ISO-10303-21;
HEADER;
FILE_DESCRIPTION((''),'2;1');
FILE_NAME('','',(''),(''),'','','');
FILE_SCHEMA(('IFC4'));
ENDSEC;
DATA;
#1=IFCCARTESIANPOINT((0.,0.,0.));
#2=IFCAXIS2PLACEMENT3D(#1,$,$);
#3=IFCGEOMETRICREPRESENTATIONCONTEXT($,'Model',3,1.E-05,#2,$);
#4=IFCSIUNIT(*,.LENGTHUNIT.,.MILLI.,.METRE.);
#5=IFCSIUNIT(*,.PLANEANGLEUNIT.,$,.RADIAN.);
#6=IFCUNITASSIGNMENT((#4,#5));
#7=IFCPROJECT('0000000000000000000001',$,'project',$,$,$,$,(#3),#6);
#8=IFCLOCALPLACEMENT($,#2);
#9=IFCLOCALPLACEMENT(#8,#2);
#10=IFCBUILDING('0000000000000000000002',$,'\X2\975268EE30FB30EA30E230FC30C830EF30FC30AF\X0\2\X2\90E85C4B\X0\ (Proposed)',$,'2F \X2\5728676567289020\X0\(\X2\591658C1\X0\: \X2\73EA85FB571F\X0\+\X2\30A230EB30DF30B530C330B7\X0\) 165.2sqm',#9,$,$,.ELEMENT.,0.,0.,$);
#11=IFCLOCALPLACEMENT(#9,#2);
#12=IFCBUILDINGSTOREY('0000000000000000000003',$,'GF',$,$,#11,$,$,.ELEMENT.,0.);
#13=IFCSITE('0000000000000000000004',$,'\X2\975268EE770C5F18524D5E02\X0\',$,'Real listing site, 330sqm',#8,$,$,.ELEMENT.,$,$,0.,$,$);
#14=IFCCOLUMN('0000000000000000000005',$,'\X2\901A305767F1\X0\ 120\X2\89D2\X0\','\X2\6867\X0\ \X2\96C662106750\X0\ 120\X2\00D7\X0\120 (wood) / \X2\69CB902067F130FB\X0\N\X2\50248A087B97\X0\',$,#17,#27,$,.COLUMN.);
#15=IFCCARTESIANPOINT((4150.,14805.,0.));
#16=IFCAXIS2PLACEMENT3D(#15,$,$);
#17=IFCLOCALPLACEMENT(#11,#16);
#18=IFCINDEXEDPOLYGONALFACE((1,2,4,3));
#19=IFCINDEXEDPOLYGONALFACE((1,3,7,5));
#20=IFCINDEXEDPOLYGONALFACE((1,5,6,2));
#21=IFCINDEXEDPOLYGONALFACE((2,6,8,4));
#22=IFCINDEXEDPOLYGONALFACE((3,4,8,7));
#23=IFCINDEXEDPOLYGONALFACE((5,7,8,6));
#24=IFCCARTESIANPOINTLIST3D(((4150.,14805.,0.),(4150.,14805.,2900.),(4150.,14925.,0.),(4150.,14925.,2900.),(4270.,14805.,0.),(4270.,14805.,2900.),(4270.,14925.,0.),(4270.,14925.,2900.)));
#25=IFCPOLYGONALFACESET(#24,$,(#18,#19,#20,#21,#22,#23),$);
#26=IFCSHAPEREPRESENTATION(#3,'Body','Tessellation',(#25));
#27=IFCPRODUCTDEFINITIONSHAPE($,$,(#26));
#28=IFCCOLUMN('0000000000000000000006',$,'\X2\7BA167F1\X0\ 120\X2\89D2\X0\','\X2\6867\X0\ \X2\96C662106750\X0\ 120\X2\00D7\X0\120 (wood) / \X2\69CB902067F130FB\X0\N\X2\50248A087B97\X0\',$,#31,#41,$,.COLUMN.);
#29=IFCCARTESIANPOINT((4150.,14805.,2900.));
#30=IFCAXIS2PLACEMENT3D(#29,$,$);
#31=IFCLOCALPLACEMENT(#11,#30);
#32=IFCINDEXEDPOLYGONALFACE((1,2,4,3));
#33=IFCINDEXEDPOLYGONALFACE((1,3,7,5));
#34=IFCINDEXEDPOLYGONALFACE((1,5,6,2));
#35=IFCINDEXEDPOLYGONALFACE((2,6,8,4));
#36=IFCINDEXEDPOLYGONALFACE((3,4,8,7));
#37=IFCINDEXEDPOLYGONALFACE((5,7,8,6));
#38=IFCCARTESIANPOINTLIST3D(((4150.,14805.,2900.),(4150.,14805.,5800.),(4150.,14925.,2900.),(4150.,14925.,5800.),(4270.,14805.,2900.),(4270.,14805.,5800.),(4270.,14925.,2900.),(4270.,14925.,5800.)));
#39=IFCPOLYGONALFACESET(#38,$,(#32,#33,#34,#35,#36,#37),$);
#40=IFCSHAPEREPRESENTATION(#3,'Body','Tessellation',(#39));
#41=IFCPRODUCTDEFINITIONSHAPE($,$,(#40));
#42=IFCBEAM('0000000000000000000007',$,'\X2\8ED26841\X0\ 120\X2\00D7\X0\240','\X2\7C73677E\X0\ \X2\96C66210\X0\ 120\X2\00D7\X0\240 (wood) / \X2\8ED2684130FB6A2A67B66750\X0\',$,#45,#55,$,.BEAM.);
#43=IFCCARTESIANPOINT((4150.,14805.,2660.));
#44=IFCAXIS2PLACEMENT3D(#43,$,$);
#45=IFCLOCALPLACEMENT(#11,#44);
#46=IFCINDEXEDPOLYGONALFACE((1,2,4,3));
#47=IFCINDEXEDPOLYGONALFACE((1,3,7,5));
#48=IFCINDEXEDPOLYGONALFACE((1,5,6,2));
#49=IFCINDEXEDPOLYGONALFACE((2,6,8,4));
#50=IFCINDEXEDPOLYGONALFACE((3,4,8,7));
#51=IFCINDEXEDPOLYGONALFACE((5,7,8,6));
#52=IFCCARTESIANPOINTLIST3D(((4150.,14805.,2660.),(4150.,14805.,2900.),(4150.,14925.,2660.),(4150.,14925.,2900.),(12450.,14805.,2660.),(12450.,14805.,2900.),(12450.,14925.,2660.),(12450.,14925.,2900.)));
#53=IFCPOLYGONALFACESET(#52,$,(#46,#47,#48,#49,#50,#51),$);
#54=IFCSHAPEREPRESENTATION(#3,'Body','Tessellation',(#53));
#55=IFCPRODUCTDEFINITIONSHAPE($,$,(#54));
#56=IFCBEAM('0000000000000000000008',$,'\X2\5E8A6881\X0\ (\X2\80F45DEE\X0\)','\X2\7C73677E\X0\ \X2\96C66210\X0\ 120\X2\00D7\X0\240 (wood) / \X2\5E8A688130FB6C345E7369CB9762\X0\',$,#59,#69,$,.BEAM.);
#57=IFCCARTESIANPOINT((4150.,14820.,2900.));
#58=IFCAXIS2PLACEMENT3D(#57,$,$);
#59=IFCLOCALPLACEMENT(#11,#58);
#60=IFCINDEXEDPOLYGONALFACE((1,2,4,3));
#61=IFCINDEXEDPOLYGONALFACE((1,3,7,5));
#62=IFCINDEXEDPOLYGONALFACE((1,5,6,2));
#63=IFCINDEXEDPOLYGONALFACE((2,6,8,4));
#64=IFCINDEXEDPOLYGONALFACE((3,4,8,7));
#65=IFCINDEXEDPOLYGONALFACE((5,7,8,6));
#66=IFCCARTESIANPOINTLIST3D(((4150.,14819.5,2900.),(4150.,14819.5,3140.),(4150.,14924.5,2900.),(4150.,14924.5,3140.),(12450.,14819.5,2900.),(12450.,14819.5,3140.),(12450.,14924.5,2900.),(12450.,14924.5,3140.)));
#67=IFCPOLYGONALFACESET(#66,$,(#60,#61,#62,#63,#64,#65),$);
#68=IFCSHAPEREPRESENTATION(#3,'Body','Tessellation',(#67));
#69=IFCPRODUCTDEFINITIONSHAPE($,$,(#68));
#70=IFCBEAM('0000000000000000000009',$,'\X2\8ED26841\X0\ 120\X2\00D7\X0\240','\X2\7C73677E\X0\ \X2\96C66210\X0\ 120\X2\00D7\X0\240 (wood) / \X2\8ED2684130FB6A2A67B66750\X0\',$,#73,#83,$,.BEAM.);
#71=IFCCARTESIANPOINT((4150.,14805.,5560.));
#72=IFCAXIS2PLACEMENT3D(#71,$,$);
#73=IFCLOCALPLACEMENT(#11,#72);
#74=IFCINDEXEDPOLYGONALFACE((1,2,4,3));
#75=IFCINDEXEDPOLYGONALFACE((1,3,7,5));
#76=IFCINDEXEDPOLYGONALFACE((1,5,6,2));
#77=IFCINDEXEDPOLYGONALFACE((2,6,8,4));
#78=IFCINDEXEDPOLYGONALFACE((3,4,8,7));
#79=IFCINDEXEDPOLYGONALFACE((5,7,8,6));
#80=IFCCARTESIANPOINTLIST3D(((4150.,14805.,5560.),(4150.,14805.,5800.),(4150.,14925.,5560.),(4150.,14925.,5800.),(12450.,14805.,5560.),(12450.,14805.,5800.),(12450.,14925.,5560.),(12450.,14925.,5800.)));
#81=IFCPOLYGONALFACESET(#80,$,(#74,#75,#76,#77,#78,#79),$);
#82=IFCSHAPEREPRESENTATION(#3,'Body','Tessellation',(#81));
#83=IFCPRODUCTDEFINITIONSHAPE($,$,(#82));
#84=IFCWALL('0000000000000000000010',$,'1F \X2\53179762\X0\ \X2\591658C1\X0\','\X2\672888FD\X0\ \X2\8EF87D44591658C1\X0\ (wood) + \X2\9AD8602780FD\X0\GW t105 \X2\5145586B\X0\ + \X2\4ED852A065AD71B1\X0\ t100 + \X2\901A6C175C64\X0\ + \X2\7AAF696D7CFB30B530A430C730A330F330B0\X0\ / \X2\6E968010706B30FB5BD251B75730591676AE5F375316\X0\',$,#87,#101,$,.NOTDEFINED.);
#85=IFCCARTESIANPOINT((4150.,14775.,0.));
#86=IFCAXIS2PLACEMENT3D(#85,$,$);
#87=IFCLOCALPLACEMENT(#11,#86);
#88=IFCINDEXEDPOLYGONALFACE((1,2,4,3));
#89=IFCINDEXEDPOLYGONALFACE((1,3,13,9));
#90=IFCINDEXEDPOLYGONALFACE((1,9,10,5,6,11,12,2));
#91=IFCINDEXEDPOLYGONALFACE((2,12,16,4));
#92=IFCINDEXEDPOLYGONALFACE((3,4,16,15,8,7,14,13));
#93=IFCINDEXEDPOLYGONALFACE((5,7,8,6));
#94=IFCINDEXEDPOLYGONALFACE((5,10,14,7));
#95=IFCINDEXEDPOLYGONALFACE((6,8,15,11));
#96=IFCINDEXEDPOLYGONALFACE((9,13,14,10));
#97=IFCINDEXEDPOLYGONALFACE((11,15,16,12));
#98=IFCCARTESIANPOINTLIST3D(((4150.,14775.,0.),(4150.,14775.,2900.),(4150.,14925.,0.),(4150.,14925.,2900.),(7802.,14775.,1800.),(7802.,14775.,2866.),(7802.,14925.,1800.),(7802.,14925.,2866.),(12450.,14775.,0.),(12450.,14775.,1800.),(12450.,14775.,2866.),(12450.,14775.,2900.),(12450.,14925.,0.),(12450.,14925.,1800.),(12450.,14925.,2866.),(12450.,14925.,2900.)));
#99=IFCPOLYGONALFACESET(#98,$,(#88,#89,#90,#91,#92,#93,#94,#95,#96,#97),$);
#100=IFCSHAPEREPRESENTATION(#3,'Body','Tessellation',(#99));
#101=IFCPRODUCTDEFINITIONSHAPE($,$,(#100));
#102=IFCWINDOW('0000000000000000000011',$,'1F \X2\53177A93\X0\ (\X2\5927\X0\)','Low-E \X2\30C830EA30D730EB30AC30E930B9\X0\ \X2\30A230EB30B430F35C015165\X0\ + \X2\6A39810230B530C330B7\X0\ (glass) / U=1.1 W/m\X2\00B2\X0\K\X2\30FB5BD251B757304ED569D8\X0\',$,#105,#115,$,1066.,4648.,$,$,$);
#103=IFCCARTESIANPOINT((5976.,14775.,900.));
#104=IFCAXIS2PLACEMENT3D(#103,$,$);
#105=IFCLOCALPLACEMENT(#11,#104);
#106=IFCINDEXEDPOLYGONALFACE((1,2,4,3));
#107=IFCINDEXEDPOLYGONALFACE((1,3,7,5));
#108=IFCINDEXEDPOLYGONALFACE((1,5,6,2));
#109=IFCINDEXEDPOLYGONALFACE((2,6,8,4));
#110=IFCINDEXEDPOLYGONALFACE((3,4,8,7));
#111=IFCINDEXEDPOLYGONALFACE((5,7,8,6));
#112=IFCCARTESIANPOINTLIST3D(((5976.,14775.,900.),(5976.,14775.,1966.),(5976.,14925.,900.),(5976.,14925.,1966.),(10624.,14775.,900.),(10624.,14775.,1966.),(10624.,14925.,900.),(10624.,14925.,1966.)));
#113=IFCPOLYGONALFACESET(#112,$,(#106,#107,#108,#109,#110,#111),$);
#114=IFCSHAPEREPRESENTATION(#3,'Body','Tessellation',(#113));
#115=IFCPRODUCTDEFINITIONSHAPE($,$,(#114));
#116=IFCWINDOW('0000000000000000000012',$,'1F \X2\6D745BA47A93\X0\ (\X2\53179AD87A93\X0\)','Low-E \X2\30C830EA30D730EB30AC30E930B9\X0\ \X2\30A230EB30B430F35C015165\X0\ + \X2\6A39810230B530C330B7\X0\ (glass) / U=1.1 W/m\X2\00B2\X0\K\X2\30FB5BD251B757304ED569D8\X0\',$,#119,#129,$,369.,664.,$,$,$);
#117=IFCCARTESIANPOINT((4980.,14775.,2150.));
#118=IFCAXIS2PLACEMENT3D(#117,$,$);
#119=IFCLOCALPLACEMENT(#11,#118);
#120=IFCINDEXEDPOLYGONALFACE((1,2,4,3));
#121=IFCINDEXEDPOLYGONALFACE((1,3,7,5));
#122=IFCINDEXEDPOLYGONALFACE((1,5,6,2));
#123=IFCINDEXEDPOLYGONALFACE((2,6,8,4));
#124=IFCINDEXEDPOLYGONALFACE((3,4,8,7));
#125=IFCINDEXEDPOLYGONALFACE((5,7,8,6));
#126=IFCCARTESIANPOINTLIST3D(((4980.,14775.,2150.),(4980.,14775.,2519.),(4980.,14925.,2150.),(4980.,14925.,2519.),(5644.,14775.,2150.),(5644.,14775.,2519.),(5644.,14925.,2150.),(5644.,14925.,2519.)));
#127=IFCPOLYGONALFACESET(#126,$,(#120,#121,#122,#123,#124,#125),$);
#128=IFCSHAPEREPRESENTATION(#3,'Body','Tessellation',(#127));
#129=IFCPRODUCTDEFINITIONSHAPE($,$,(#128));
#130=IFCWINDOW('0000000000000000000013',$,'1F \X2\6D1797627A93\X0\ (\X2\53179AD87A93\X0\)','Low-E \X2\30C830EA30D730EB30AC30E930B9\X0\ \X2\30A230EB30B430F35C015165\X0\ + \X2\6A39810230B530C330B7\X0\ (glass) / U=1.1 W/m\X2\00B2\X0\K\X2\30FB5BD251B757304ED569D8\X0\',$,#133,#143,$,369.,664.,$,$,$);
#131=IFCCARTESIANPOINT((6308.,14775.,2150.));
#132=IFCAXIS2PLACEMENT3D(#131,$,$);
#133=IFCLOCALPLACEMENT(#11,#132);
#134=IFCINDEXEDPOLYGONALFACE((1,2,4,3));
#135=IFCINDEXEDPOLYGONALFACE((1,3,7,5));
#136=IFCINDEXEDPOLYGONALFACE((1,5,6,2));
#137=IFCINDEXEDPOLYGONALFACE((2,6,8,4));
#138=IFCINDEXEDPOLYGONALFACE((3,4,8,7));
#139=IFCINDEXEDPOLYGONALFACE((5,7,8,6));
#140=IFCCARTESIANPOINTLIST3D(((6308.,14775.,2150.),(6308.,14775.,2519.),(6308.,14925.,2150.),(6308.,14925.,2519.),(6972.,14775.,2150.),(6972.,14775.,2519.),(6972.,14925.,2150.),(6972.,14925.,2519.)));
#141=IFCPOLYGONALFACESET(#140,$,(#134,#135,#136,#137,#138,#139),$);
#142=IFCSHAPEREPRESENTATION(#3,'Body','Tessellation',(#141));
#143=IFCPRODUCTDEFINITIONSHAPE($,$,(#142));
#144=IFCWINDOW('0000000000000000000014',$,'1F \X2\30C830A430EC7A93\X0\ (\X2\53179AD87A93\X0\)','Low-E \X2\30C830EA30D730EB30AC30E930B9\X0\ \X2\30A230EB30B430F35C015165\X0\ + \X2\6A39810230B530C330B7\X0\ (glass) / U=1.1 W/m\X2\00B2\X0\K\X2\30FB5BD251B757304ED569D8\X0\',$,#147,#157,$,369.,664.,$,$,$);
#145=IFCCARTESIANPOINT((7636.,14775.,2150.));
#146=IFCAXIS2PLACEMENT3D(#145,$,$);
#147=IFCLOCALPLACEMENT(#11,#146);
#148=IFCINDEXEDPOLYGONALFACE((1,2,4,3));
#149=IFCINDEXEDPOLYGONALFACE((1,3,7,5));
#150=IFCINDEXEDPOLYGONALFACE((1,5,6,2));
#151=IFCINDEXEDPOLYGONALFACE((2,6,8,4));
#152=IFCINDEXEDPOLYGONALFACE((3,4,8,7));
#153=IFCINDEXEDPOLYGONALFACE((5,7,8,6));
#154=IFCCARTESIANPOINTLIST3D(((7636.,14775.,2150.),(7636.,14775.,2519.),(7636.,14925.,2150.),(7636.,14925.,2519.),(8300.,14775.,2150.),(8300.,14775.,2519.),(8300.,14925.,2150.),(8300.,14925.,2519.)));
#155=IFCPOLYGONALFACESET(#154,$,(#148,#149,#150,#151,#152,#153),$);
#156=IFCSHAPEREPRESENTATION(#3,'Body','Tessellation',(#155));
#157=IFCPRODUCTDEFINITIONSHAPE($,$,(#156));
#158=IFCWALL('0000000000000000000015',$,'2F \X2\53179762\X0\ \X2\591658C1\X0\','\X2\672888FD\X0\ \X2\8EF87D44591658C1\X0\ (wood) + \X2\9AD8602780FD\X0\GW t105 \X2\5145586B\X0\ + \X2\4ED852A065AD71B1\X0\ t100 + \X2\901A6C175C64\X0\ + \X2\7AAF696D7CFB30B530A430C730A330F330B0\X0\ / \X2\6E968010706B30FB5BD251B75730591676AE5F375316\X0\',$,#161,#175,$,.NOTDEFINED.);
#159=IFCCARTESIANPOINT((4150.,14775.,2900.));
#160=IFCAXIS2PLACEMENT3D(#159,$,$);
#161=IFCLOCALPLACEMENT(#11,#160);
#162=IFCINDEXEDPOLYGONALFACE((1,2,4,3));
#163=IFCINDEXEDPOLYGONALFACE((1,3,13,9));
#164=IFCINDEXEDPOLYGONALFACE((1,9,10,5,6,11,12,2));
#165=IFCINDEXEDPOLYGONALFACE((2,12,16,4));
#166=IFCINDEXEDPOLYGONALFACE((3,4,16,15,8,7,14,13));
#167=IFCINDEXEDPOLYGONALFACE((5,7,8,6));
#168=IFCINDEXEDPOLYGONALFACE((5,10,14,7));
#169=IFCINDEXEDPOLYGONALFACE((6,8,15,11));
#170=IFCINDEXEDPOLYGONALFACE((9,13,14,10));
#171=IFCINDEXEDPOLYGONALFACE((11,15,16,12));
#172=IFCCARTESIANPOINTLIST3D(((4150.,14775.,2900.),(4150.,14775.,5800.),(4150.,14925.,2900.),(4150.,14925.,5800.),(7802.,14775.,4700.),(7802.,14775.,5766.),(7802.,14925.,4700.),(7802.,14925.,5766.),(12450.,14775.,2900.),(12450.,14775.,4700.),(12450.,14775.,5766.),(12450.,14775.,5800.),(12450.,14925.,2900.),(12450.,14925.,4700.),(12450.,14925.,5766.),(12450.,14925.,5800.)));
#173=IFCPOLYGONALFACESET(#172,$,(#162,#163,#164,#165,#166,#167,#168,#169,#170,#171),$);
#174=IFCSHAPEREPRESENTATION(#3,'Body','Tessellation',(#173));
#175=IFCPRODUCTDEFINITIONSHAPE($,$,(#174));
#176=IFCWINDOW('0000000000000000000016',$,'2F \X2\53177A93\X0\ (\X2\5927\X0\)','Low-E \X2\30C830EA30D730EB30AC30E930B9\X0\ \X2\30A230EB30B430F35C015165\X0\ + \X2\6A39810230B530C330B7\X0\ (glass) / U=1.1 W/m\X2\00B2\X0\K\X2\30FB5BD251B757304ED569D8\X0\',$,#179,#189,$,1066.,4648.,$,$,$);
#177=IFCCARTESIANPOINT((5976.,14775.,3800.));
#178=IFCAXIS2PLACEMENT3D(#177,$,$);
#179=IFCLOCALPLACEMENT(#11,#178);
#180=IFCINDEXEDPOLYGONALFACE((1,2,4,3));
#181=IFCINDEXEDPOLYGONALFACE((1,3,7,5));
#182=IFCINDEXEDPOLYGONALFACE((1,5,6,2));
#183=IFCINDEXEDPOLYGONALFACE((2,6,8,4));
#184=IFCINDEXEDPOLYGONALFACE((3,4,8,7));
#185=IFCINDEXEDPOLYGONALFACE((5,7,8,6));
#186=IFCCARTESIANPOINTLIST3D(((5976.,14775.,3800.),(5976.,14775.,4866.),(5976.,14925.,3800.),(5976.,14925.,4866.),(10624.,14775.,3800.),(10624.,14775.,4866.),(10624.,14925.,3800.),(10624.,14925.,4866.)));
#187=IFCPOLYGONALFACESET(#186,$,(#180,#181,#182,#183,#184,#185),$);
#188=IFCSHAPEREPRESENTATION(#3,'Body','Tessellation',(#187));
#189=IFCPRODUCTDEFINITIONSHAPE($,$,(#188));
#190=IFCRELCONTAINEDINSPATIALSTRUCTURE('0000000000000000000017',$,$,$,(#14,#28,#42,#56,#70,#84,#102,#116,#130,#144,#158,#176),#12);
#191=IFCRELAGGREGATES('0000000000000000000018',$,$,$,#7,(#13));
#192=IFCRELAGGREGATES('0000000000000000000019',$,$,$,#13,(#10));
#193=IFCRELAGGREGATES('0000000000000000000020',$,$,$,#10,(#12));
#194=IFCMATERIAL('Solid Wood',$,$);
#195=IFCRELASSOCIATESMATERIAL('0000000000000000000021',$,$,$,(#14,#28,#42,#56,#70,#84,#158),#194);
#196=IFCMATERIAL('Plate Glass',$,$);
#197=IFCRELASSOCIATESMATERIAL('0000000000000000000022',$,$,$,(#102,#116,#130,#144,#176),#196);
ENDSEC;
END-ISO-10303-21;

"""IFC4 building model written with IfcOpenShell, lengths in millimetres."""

from ifc_helpers import new_model, si_unit, frame, frame_2d, origin, place, context, project, spatial, rectangle, extrude, material, element, fill, save


model = new_model("IFC4")

# Units and contexts
model_context = context("Model", 3, precision=1e-05, world=origin())
ifc_project = project(units=[si_unit("LENGTHUNIT", "METRE", prefix="MILLI"), si_unit("PLANEANGLEUNIT", "RADIAN")], contexts=[model_context])

# Site, building, storey
site_placement = place(None, origin())
site = spatial("IfcSite", under=ifc_project, at=site_placement, Name="青森県弘前市", ObjectType="Real listing site, 330sqm", CompositionType="ELEMENT", RefElevation=0.0)
building_placement = place(site_placement, origin())
building = spatial("IfcBuilding", under=site, at=building_placement, Name="青森・リモートワーク2部屋 (Proposed)", ObjectType="2F 在来木造(外壁: 珪藻土+アルミサッシ) 165.2sqm", CompositionType="ELEMENT", ElevationOfRefHeight=0.0, ElevationOfTerrain=0.0)
storey_placement = place(building_placement, origin())
storey = spatial("IfcBuildingStorey", under=building, at=storey_placement, Name="GF", CompositionType="ELEMENT", Elevation=0.0)

# Columns
ifc_material_1 = material(Name="Solid Wood")
column_1_placement = place(storey_placement, frame((4150.0, 14805.0, 0.0)))
element("IfcColumn", 1, at=column_1_placement, inside=storey, material=ifc_material_1, Name="通し柱 120角", Description="桧 集成材 120×120 (wood) / 構造柱・N値計算", PredefinedType="COLUMN", context=model_context, shape_type="SweptSolid", body=[
    extrude(rectangle(XDim=120.0, YDim=120.0, at=frame_2d((60.0, 60.0))), frame((4150.0, 14805.0, 0.0)), (0.0, 0.0, 1.0), 2900.0),
])
column_2_placement = place(storey_placement, frame((4150.0, 14805.0, 2900.0)))
element("IfcColumn", 2, at=column_2_placement, inside=storey, material=ifc_material_1, Name="管柱 120角", Description="桧 集成材 120×120 (wood) / 構造柱・N値計算", PredefinedType="COLUMN", context=model_context, shape_type="SweptSolid", body=[
    extrude(rectangle(XDim=120.0, YDim=120.0, at=frame_2d((60.0, 60.0))), frame((4150.0, 14805.0, 2900.0)), (0.0, 0.0, 1.0), 2900.0),
])

# Beams
beam_1_placement = place(storey_placement, frame((4150.0, 14805.0, 2660.0)))
element("IfcBeam", 3, at=beam_1_placement, inside=storey, material=ifc_material_1, Name="軒桁 120×240", Description="米松 集成 120×240 (wood) / 軒桁・横架材", PredefinedType="BEAM", context=model_context, shape_type="SweptSolid", body=[
    extrude(rectangle(XDim=8300.0, YDim=120.0, at=frame_2d((4150.0, 60.0))), frame((4150.0, 14805.0, 2660.0)), (0.0, 0.0, 1.0), 240.0),
])
beam_2_placement = place(storey_placement, frame((4150.0, 14820.0, 2900.0)))
element("IfcBeam", 4, at=beam_2_placement, inside=storey, material=ifc_material_1, Name="床梁 (胴差)", Description="米松 集成 120×240 (wood) / 床梁・水平構面", PredefinedType="BEAM", context=model_context, shape_type="SweptSolid", body=[
    extrude(rectangle(XDim=8300.0, YDim=105.0, at=frame_2d((4150.0, 52.0))), frame((4150.0, 14820.0, 2900.0)), (0.0, 0.0, 1.0), 240.0),
])
beam_3_placement = place(storey_placement, frame((4150.0, 14805.0, 5560.0)))
element("IfcBeam", 5, at=beam_3_placement, inside=storey, material=ifc_material_1, Name="軒桁 120×240", Description="米松 集成 120×240 (wood) / 軒桁・横架材", PredefinedType="BEAM", context=model_context, shape_type="SweptSolid", body=[
    extrude(rectangle(XDim=8300.0, YDim=120.0, at=frame_2d((4150.0, 60.0))), frame((4150.0, 14805.0, 5560.0)), (0.0, 0.0, 1.0), 240.0),
])

# Wall, openings, windows
wall_1_placement = place(storey_placement, frame((4150.0, 14775.0, 0.0)))
wall_1 = element("IfcWall", 6, at=wall_1_placement, inside=storey, material=ifc_material_1, Name="1F 北面 外壁", Description="木製 軸組外壁 (wood) + 高性能GW t105 充填 + 付加断熱 t100 + 通気層 + 窯業系サイディング / 準耐火・寒冷地外皮強化", PredefinedType="NOTDEFINED", context=model_context, shape_type="SweptSolid", body=[
    extrude(rectangle(XDim=8300.0, YDim=150.0, at=frame_2d((4150.0, 75.0))), frame((4150.0, 14775.0, 0.0)), (0.0, 0.0, 1.0), 2900.0),
])
opening_1_placement = place(storey_placement, frame((5976.0, 14775.0, 900.0)))
opening_1 = element("IfcOpeningElement", 7, at=opening_1_placement, cuts=wall_1, PredefinedType="NOTDEFINED", context=model_context, shape_type="SweptSolid", body=[
    extrude(rectangle(XDim=4648.0, YDim=150.0, at=frame_2d((2324.0, 75.0))), frame((5976.0, 14775.0, 900.0)), (0.0, 0.0, 1.0), 1066.0),
])
opening_2_placement = place(storey_placement, frame((4980.0, 14775.0, 2150.0)))
opening_2 = element("IfcOpeningElement", 8, at=opening_2_placement, cuts=wall_1, PredefinedType="NOTDEFINED", context=model_context, shape_type="SweptSolid", body=[
    extrude(rectangle(XDim=664.0, YDim=150.0, at=frame_2d((332.0, 75.0))), frame((4980.0, 14775.0, 2150.0)), (0.0, 0.0, 1.0), 369.0),
])
opening_3_placement = place(storey_placement, frame((6308.0, 14775.0, 2150.0)))
opening_3 = element("IfcOpeningElement", 9, at=opening_3_placement, cuts=wall_1, PredefinedType="NOTDEFINED", context=model_context, shape_type="SweptSolid", body=[
    extrude(rectangle(XDim=664.0, YDim=150.0, at=frame_2d((332.0, 75.0))), frame((6308.0, 14775.0, 2150.0)), (0.0, 0.0, 1.0), 369.0),
])
opening_4_placement = place(storey_placement, frame((7636.0, 14775.0, 2150.0)))
opening_4 = element("IfcOpeningElement", 10, at=opening_4_placement, cuts=wall_1, PredefinedType="NOTDEFINED", context=model_context, shape_type="SweptSolid", body=[
    extrude(rectangle(XDim=664.0, YDim=150.0, at=frame_2d((332.0, 75.0))), frame((7636.0, 14775.0, 2150.0)), (0.0, 0.0, 1.0), 369.0),
])
ifc_material_2 = material(Name="Plate Glass")
window_1_placement = place(storey_placement, frame((5976.0, 14775.0, 900.0)))
window_1 = element("IfcWindow", 11, at=window_1_placement, inside=storey, material=ifc_material_2, Name="1F 北窓 (大)", Description="Low-E トリプルガラス アルゴン封入 + 樹脂サッシ (glass) / U=1.1 W/m²K・寒冷地仕様", OverallHeight=1066.0, OverallWidth=4648.0, context=model_context, shape_type="SweptSolid", body=[
    extrude(rectangle(XDim=4648.0, YDim=150.0, at=frame_2d((2324.0, 75.0))), frame((5976.0, 14775.0, 900.0)), (0.0, 0.0, 1.0), 1066.0),
])
fill(opening_1, window_1)
window_2_placement = place(storey_placement, frame((4980.0, 14775.0, 2150.0)))
window_2 = element("IfcWindow", 12, at=window_2_placement, inside=storey, material=ifc_material_2, Name="1F 浴室窓 (北高窓)", Description="Low-E トリプルガラス アルゴン封入 + 樹脂サッシ (glass) / U=1.1 W/m²K・寒冷地仕様", OverallHeight=369.0, OverallWidth=664.0, context=model_context, shape_type="SweptSolid", body=[
    extrude(rectangle(XDim=664.0, YDim=150.0, at=frame_2d((332.0, 75.0))), frame((4980.0, 14775.0, 2150.0)), (0.0, 0.0, 1.0), 369.0),
])
fill(opening_2, window_2)
window_3_placement = place(storey_placement, frame((6308.0, 14775.0, 2150.0)))
window_3 = element("IfcWindow", 13, at=window_3_placement, inside=storey, material=ifc_material_2, Name="1F 洗面窓 (北高窓)", Description="Low-E トリプルガラス アルゴン封入 + 樹脂サッシ (glass) / U=1.1 W/m²K・寒冷地仕様", OverallHeight=369.0, OverallWidth=664.0, context=model_context, shape_type="SweptSolid", body=[
    extrude(rectangle(XDim=664.0, YDim=150.0, at=frame_2d((332.0, 75.0))), frame((6308.0, 14775.0, 2150.0)), (0.0, 0.0, 1.0), 369.0),
])
fill(opening_3, window_3)
window_4_placement = place(storey_placement, frame((7636.0, 14775.0, 2150.0)))
window_4 = element("IfcWindow", 14, at=window_4_placement, inside=storey, material=ifc_material_2, Name="1F トイレ窓 (北高窓)", Description="Low-E トリプルガラス アルゴン封入 + 樹脂サッシ (glass) / U=1.1 W/m²K・寒冷地仕様", OverallHeight=369.0, OverallWidth=664.0, context=model_context, shape_type="SweptSolid", body=[
    extrude(rectangle(XDim=664.0, YDim=150.0, at=frame_2d((332.0, 75.0))), frame((7636.0, 14775.0, 2150.0)), (0.0, 0.0, 1.0), 369.0),
])
fill(opening_4, window_4)

# Wall, opening, window
wall_2_placement = place(storey_placement, frame((4150.0, 14775.0, 2900.0)))
wall_2 = element("IfcWall", 15, at=wall_2_placement, inside=storey, material=ifc_material_1, Name="2F 北面 外壁", Description="木製 軸組外壁 (wood) + 高性能GW t105 充填 + 付加断熱 t100 + 通気層 + 窯業系サイディング / 準耐火・寒冷地外皮強化", PredefinedType="NOTDEFINED", context=model_context, shape_type="SweptSolid", body=[
    extrude(rectangle(XDim=8300.0, YDim=150.0, at=frame_2d((4150.0, 75.0))), frame((4150.0, 14775.0, 2900.0)), (0.0, 0.0, 1.0), 2900.0),
])
opening_5_placement = place(storey_placement, frame((5976.0, 14775.0, 3800.0)))
opening_5 = element("IfcOpeningElement", 16, at=opening_5_placement, cuts=wall_2, PredefinedType="NOTDEFINED", context=model_context, shape_type="SweptSolid", body=[
    extrude(rectangle(XDim=4648.0, YDim=150.0, at=frame_2d((2324.0, 75.0))), frame((5976.0, 14775.0, 3800.0)), (0.0, 0.0, 1.0), 1066.0),
])
window_5_placement = place(storey_placement, frame((5976.0, 14775.0, 3800.0)))
window_5 = element("IfcWindow", 17, at=window_5_placement, inside=storey, material=ifc_material_2, Name="2F 北窓 (大)", Description="Low-E トリプルガラス アルゴン封入 + 樹脂サッシ (glass) / U=1.1 W/m²K・寒冷地仕様", OverallHeight=1066.0, OverallWidth=4648.0, context=model_context, shape_type="SweptSolid", body=[
    extrude(rectangle(XDim=4648.0, YDim=150.0, at=frame_2d((2324.0, 75.0))), frame((5976.0, 14775.0, 3800.0)), (0.0, 0.0, 1.0), 1066.0),
])
fill(opening_5, window_5)

save(model, "model.ifc")
